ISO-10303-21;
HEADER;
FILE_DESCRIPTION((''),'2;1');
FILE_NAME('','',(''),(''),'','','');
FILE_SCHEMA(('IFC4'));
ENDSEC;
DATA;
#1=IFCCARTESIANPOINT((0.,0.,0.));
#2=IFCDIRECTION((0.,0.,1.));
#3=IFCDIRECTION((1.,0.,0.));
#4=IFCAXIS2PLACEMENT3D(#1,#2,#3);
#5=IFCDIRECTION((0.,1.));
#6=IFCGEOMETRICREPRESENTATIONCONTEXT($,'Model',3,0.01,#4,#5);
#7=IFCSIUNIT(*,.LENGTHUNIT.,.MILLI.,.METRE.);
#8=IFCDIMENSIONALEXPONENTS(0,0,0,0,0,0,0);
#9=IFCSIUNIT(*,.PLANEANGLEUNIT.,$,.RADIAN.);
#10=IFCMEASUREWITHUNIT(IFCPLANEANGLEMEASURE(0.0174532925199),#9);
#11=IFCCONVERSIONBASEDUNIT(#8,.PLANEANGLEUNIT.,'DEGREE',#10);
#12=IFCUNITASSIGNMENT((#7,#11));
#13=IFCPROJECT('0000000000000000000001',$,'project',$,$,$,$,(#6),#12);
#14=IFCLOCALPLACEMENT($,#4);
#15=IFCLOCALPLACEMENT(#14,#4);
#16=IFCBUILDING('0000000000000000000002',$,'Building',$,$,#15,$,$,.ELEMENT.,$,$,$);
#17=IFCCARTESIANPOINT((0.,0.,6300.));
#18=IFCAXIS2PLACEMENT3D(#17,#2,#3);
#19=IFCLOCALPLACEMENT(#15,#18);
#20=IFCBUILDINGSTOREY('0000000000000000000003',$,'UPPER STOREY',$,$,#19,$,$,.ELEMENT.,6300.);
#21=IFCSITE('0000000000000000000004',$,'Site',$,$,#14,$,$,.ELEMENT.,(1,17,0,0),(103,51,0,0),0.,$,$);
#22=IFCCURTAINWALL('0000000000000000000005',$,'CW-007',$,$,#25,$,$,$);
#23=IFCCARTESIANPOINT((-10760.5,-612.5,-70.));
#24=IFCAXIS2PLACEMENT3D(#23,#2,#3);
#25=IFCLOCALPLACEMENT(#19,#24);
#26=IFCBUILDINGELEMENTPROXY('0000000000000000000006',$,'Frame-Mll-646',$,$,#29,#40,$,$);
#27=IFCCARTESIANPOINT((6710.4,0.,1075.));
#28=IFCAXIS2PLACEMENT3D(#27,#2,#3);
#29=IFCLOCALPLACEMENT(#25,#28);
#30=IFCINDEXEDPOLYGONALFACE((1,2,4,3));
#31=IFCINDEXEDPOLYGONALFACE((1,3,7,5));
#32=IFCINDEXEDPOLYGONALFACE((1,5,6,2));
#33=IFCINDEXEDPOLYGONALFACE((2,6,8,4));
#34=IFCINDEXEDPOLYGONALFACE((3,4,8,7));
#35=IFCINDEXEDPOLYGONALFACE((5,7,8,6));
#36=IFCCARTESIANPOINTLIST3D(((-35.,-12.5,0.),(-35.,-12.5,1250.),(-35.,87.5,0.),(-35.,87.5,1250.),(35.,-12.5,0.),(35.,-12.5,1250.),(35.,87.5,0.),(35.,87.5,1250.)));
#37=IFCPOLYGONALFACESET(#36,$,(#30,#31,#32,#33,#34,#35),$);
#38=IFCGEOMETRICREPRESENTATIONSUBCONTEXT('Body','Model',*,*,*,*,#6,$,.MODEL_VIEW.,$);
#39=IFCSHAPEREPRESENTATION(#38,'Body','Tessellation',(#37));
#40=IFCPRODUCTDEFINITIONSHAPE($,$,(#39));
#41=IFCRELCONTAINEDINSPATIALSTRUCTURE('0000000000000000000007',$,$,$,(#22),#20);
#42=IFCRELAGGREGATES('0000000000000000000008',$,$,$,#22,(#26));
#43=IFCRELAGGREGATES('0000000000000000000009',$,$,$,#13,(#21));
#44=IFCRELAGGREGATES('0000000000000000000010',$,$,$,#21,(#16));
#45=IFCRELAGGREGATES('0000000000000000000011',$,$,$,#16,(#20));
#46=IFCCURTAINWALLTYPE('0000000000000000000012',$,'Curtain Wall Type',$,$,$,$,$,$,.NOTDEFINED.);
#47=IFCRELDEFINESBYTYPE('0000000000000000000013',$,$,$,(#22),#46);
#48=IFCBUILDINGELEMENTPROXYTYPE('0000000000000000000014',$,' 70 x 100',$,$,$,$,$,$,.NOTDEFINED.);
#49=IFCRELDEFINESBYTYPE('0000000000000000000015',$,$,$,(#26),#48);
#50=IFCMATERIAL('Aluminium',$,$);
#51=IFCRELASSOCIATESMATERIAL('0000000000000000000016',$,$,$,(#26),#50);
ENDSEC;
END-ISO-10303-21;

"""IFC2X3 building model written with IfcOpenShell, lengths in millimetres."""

from ifc_helpers import new_model, entity, si_unit, converted_unit, direction, frame, origin_with_axes, place, context, subcontext, project, spatial, polyline, outline, extrude, material, type_object, element, aggregate, save


model = new_model("IFC2X3")

# Units and contexts
model_context = context("Model", 3, precision=0.01, world=origin_with_axes(), true_north=direction((0.0, 1.0)))
body_context = subcontext(model_context, "Body", "Model", "MODEL_VIEW")
ifc_project = project(units=[si_unit("LENGTHUNIT", "METRE", prefix="MILLI"), converted_unit("PLANEANGLEUNIT", "DEGREE", entity("IfcPlaneAngleMeasure", 0.0174532925199), si_unit("PLANEANGLEUNIT", "RADIAN"), dimensions=[0, 0, 0, 0, 0, 0, 0])], contexts=[model_context])

# Site, building, storey
site_placement = place(None, origin_with_axes())
site = spatial("IfcSite", under=ifc_project, at=site_placement, Name="Site", CompositionType="ELEMENT", RefLatitude=(1, 17, 0, 0), RefLongitude=(103, 51, 0, 0), RefElevation=0.0)
building_placement = place(site_placement, origin_with_axes())
building = spatial("IfcBuilding", under=site, at=building_placement, Name="Building", CompositionType="ELEMENT")
storey_placement = place(building_placement, frame((0.0, 0.0, 6300.0), z_axis=(0.0, 0.0, 1.0), x_axis=(1.0, 0.0, 0.0)))
storey = spatial("IfcBuildingStorey", under=building, at=storey_placement, Name="UPPER STOREY", CompositionType="ELEMENT", Elevation=6300.0)

# Curtain wall, building element proxy
curtain_wall_type = type_object("IfcCurtainWallType", Name="Curtain Wall Type", PredefinedType="NOTDEFINED")
curtain_wall_placement = place(storey_placement, frame((-10760.5, -612.5, -70.0), z_axis=(0.0, 0.0, 1.0), x_axis=(1.0, 0.0, 0.0)))
curtain_wall = element("IfcCurtainWall", 1, at=curtain_wall_placement, inside=storey, type_object=curtain_wall_type, Name="CW-007")
ifc_material_1 = material(Name="Aluminium")
building_element_proxy_type_1 = type_object("IfcBuildingElementProxyType", Name=" 70 x 100", PredefinedType="NOTDEFINED")
proxy_1_placement = place(curtain_wall_placement, frame((6710.4, 0.0, 1075.0), z_axis=(0.0, 0.0, 1.0), x_axis=(1.0, 0.0, 0.0)))
proxy_1 = element("IfcBuildingElementProxy", 2, at=proxy_1_placement, type_object=building_element_proxy_type_1, material=ifc_material_1, Name="Frame-Mll-646", context=body_context, shape_type="SweptSolid", body=[
    extrude(outline(polyline([(35.0, 87.5), (-35.0, 87.5), (-35.0, -12.5), (35.0, -12.5), (35.0, 87.5)])), frame((0.0, 0.0, 0.0), z_axis=(0.0, 0.0, 1.0), x_axis=(1.0, 0.0, 0.0)), (0.0, 0.0, 1.0), 1250.0),
])
aggregate(curtain_wall, [proxy_1])

save(model, "model.ifc")
